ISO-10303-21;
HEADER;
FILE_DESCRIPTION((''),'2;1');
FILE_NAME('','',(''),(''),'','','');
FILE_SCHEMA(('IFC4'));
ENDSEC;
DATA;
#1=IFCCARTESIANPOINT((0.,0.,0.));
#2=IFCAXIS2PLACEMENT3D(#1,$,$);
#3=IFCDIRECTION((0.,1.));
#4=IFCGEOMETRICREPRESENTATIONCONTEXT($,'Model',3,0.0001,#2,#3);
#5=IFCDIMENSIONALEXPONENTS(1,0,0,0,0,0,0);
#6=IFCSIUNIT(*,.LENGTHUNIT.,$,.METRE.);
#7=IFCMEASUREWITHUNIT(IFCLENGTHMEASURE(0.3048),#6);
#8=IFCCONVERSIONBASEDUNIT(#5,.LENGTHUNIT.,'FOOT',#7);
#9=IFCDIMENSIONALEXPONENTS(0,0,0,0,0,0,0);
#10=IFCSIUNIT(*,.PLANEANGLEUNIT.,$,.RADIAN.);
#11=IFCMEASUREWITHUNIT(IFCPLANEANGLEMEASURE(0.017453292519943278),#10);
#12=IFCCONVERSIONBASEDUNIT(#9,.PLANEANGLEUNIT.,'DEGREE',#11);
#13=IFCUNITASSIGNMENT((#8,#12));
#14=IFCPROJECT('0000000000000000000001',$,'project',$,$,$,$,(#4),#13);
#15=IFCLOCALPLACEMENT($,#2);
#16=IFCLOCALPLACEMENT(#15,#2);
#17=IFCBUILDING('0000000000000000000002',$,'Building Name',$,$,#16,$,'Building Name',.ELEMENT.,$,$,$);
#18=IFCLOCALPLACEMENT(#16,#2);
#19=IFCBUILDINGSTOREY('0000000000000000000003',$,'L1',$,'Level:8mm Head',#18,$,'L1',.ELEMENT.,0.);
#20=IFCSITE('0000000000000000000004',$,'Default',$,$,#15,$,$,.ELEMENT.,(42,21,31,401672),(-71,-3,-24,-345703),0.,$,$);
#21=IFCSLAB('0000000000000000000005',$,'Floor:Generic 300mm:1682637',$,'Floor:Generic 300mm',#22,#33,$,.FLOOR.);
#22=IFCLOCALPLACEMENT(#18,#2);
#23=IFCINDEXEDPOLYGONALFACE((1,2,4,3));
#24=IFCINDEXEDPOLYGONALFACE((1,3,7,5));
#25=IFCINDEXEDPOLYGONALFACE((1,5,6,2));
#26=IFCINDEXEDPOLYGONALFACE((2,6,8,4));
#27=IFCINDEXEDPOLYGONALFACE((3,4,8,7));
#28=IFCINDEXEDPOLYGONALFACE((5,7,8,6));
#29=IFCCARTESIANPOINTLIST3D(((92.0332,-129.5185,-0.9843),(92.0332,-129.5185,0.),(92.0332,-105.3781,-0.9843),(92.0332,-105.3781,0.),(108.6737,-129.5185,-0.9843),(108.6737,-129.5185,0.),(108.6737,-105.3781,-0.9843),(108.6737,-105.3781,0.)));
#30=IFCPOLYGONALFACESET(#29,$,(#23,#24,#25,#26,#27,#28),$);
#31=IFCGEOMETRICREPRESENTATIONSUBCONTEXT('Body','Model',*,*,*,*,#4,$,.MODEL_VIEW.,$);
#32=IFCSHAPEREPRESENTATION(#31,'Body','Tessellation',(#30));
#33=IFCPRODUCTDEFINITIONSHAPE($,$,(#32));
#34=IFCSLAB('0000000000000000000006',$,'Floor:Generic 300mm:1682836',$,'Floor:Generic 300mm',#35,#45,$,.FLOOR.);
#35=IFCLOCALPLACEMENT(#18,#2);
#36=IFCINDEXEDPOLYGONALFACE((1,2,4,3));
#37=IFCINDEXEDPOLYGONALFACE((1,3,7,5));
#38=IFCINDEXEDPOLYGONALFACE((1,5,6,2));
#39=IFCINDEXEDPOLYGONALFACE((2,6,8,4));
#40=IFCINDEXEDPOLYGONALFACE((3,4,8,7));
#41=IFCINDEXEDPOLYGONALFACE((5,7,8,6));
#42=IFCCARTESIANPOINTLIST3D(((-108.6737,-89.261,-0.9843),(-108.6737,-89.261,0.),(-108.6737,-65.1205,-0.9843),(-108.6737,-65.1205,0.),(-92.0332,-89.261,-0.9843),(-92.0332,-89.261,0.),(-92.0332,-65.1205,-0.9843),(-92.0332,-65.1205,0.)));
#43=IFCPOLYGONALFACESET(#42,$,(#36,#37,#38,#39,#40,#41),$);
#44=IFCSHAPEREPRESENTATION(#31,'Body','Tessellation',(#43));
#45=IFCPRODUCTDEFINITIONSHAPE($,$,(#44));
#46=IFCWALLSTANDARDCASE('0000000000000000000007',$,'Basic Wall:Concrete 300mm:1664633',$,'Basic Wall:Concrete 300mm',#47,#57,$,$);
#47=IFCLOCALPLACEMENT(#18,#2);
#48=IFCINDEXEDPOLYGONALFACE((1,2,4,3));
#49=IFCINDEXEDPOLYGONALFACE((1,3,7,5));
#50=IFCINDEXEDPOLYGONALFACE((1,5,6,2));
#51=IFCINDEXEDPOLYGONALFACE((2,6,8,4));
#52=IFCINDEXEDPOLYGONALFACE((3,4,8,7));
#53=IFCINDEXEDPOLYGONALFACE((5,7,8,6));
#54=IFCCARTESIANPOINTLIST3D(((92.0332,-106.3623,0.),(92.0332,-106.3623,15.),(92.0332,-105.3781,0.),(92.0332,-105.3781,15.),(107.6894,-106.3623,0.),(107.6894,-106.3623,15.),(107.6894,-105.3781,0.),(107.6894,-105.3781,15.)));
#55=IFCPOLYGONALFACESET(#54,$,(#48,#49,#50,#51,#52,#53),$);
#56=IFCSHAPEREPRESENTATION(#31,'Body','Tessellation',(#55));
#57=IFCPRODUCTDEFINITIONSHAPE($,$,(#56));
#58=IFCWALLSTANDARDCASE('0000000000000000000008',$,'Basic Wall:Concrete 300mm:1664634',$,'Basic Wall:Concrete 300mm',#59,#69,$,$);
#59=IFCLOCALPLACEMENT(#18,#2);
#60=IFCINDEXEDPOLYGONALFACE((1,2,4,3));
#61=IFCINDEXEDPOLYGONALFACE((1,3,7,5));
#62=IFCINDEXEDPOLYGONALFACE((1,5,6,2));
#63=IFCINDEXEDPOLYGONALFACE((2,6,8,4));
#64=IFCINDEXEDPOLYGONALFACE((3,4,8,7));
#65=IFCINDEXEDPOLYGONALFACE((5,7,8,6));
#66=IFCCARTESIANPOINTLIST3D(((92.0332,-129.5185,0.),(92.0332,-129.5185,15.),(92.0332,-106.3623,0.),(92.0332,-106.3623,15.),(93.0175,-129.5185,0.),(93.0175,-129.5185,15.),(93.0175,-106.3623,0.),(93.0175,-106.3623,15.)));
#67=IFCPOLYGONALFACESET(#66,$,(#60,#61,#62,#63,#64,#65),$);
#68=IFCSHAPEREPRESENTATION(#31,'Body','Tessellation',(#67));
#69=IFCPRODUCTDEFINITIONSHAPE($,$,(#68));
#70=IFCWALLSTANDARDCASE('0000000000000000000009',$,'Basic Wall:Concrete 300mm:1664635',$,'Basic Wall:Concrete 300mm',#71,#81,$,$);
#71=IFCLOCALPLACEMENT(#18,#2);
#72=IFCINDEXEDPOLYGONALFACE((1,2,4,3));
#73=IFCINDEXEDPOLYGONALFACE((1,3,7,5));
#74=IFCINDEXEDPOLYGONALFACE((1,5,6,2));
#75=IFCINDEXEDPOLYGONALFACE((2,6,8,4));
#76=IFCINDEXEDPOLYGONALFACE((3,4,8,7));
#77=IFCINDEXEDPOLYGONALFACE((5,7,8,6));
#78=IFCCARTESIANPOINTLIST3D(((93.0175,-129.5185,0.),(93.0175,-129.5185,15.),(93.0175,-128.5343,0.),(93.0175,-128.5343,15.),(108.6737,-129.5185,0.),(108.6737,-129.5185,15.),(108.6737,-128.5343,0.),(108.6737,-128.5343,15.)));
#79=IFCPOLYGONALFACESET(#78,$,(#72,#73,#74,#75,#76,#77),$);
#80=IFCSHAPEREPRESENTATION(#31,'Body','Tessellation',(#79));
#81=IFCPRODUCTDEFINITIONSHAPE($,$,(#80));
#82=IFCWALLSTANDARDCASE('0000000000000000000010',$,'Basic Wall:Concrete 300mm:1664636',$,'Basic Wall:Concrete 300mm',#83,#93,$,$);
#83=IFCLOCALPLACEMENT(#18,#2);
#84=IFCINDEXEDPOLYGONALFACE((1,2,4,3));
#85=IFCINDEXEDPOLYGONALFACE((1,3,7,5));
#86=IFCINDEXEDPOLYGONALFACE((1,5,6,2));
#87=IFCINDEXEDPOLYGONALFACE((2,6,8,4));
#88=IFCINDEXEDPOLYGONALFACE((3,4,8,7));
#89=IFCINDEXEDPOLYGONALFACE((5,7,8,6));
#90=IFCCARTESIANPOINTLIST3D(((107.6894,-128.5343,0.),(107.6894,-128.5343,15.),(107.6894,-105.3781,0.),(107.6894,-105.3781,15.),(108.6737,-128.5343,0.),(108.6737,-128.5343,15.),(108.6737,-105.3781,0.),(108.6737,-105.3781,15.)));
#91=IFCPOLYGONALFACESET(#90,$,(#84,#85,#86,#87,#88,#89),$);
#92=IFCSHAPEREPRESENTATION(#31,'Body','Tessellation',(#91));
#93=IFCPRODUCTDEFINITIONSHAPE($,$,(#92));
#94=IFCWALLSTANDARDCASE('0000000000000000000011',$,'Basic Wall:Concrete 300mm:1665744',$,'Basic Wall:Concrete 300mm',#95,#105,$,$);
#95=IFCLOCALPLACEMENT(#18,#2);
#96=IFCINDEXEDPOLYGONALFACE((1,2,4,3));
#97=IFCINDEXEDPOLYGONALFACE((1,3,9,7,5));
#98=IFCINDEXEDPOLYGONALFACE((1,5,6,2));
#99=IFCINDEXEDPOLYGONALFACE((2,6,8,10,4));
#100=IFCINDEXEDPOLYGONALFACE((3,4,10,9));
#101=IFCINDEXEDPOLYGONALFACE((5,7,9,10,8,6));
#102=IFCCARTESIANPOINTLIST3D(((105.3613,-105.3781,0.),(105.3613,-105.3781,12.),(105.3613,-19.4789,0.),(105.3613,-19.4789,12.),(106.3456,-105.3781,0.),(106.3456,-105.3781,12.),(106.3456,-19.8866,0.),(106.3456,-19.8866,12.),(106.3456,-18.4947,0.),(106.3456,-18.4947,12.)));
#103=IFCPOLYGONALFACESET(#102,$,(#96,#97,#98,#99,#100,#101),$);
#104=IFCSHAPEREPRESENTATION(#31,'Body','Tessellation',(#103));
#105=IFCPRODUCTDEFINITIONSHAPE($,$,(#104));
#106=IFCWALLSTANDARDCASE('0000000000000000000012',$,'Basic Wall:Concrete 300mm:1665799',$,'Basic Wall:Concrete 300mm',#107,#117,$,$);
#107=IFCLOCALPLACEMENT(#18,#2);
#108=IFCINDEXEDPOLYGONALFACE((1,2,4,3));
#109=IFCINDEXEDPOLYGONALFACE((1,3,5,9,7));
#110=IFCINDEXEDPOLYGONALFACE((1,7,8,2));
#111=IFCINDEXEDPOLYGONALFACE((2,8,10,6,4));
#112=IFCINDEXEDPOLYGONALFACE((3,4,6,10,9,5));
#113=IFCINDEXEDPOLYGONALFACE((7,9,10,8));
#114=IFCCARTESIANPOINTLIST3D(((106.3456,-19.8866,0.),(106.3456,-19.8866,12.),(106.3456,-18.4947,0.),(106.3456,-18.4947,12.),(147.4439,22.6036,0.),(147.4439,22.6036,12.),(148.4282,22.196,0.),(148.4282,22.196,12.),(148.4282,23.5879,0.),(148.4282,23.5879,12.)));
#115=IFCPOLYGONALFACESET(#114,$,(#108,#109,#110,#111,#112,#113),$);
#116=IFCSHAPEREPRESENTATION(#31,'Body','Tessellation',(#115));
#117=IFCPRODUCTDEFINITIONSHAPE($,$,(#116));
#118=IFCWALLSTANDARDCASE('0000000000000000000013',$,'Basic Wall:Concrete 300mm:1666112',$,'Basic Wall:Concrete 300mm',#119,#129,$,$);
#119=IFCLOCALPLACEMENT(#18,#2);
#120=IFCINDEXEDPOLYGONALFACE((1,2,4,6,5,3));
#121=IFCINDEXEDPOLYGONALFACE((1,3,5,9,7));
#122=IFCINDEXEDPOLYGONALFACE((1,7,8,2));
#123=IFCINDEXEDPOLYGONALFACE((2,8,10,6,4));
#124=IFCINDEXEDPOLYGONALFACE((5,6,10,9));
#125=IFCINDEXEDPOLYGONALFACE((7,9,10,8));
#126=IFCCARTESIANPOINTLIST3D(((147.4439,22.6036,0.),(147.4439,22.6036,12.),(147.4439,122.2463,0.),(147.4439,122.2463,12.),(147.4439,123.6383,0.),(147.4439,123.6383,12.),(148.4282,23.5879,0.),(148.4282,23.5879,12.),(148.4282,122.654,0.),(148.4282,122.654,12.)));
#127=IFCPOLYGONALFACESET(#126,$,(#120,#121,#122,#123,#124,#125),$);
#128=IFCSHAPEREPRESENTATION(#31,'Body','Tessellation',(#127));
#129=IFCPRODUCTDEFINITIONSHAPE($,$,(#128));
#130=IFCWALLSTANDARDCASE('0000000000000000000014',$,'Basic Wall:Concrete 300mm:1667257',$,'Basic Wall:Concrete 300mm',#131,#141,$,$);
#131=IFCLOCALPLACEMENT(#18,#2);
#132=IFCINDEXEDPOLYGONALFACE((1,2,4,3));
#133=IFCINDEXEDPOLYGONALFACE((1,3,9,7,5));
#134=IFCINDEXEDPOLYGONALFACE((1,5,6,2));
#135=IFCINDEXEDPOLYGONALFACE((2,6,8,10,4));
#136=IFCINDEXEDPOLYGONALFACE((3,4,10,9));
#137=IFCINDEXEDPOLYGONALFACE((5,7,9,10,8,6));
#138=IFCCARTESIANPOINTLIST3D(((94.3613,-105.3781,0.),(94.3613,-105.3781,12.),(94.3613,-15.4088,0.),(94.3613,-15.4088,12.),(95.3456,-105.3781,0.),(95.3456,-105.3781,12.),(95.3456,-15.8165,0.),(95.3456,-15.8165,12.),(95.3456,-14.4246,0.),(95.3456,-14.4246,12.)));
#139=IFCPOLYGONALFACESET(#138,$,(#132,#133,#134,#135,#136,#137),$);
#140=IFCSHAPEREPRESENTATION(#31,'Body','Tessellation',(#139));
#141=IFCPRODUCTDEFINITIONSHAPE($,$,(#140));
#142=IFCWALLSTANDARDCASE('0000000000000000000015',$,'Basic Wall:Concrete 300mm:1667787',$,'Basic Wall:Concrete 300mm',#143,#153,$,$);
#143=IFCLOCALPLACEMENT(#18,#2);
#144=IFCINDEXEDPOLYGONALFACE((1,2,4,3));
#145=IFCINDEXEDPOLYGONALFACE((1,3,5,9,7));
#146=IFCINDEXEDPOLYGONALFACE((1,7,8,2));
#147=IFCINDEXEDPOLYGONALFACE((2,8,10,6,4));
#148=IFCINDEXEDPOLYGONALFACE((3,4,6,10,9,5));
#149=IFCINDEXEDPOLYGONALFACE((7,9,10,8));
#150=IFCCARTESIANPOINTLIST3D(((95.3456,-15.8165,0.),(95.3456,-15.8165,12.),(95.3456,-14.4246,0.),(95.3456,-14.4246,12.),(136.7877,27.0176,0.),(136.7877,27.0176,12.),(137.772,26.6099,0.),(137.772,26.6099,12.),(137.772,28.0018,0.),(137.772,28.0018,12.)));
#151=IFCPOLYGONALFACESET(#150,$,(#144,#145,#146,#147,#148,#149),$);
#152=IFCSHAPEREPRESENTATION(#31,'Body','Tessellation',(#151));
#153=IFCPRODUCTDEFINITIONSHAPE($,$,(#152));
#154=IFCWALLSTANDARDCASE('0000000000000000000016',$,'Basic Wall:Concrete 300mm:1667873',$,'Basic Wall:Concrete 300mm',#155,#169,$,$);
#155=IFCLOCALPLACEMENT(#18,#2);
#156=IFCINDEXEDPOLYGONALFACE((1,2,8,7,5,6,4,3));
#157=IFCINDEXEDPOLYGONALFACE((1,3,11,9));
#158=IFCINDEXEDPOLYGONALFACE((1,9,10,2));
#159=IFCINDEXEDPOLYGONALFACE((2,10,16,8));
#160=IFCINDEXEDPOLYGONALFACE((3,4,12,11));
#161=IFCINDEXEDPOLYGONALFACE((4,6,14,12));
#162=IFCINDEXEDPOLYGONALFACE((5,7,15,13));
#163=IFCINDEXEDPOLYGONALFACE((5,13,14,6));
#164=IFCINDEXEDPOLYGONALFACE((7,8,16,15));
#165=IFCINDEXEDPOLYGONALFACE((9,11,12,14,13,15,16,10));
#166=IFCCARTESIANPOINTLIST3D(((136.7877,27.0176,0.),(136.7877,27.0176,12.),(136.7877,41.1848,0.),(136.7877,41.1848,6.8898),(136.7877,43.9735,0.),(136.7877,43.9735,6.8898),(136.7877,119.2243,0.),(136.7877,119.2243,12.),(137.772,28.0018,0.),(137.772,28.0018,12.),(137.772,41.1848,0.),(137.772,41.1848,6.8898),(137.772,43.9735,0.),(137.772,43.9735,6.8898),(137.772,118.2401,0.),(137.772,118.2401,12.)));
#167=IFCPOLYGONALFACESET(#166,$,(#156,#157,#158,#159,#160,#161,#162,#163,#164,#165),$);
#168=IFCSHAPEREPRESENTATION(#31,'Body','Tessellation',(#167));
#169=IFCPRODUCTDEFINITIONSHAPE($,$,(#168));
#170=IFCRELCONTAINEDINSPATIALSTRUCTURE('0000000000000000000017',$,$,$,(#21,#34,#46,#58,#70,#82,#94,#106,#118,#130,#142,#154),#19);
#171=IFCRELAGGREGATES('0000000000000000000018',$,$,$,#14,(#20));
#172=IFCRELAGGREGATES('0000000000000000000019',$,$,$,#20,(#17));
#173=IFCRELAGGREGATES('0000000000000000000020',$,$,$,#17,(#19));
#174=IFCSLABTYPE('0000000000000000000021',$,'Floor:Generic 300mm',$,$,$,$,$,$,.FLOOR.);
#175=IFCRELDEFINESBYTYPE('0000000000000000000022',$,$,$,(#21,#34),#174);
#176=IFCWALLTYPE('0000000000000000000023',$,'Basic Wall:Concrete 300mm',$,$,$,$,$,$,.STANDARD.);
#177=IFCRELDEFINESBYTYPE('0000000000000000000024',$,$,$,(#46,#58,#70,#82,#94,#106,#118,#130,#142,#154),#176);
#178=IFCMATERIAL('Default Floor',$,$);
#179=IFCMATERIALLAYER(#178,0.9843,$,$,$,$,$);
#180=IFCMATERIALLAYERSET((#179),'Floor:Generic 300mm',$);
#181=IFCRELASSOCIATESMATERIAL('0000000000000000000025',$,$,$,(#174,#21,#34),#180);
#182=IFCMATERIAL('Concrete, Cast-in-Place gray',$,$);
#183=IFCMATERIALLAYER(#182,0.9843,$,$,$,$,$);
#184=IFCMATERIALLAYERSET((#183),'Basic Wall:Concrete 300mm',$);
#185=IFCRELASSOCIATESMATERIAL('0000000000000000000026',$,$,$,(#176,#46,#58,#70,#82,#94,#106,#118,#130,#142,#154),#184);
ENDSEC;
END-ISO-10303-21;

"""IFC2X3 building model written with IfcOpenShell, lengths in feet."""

from ifc_helpers import new_model, entity, si_unit, converted_unit, direction, frame, frame_2d, origin, place, context, subcontext, project, spatial, polyline, rectangle, outline, extrude, material, layer, layer_set, layer_usage, type_object, element, save


model = new_model("IFC2X3")

# Units and contexts
model_context = context("Model", 3, precision=0.0001, world=origin(), true_north=direction((0.0, 1.0)))
body_context = subcontext(model_context, "Body", "Model", "MODEL_VIEW")
ifc_project = project(units=[converted_unit("LENGTHUNIT", "FOOT", entity("IfcLengthMeasure", 0.3048), si_unit("LENGTHUNIT", "METRE"), dimensions=[1, 0, 0, 0, 0, 0, 0]), converted_unit("PLANEANGLEUNIT", "DEGREE", entity("IfcPlaneAngleMeasure", 0.017453292519943278), si_unit("PLANEANGLEUNIT", "RADIAN"), dimensions=[0, 0, 0, 0, 0, 0, 0])], contexts=[model_context])

# Site, building, storey
site_placement = place(None, origin())
site = spatial("IfcSite", under=ifc_project, at=site_placement, Name="Default", CompositionType="ELEMENT", RefLatitude=(42, 21, 31, 401672), RefLongitude=(-71, -3, -24, -345703), RefElevation=0.0)
building_placement = place(site_placement, origin())
building = spatial("IfcBuilding", under=site, at=building_placement, Name="Building Name", LongName="Building Name", CompositionType="ELEMENT")
storey_placement = place(building_placement, origin())
storey = spatial("IfcBuildingStorey", under=building, at=storey_placement, Name="L1", ObjectType="Level:8mm Head", LongName="L1", CompositionType="ELEMENT", Elevation=0.0)

# Slabs
ifc_material_1 = material(Name="Default Floor")
ifc_layer_1 = layer(ifc_material_1, 0.9843)
ifc_layer_set_1 = layer_set([ifc_layer_1], Name="Floor:Generic 300mm")
slab_type = type_object("IfcSlabType", Name="Floor:Generic 300mm", PredefinedType="FLOOR", material=ifc_layer_set_1)
ifc_layer_usage_1 = layer_usage(ifc_layer_set_1, "AXIS3", "POSITIVE", 0.0)
slab_1_placement = place(storey_placement, origin())
element("IfcSlab", 1, at=slab_1_placement, inside=storey, type_object=slab_type, material=ifc_layer_usage_1, Name="Floor:Generic 300mm:1682637", ObjectType="Floor:Generic 300mm", PredefinedType="FLOOR", context=body_context, shape_type="SweptSolid", body=[
    extrude(rectangle(XDim=24.1404, YDim=16.6404, at=frame_2d((0.0, 0.0), x_axis=(1.0, 0.0))), frame((100.3535, -117.4483, 0.0), z_axis=(0.0, 0.0, -1.0), x_axis=(0.0, 1.0, 0.0)), (0.0, 0.0, 1.0), 0.9843),
])
ifc_layer_usage_2 = layer_usage(ifc_layer_set_1, "AXIS3", "POSITIVE", 0.0)
slab_2_placement = place(storey_placement, origin())
element("IfcSlab", 2, at=slab_2_placement, inside=storey, type_object=slab_type, material=ifc_layer_usage_2, Name="Floor:Generic 300mm:1682836", ObjectType="Floor:Generic 300mm", PredefinedType="FLOOR", context=body_context, shape_type="SweptSolid", body=[
    extrude(rectangle(XDim=24.1404, YDim=16.6404, at=frame_2d((0.0, 0.0), x_axis=(1.0, 0.0))), frame((-100.3535, -77.1908, 0.0), z_axis=(0.0, 0.0, -1.0), x_axis=(0.0, 1.0, 0.0)), (0.0, 0.0, 1.0), 0.9843),
])

# Walls
ifc_material_2 = material(Name="Concrete, Cast-in-Place gray")
ifc_layer_2 = layer(ifc_material_2, 0.9843)
ifc_layer_set_2 = layer_set([ifc_layer_2], Name="Basic Wall:Concrete 300mm")
ifc_layer_usage_3 = layer_usage(ifc_layer_set_2, "AXIS2", "NEGATIVE", 0.4921)
wall_type = type_object("IfcWallType", Name="Basic Wall:Concrete 300mm", PredefinedType="STANDARD", material=ifc_layer_set_2)
wall_1_placement = place(storey_placement, frame((92.0332, -105.8702, 0.0)))
element("IfcWallStandardCase", 3, at=wall_1_placement, inside=storey, type_object=wall_type, material=ifc_layer_usage_3, Name="Basic Wall:Concrete 300mm:1664633", ObjectType="Basic Wall:Concrete 300mm", context=body_context, shape_type="SweptSolid", body=[
    extrude(rectangle(XDim=15.6562, YDim=0.9843, at=frame_2d((7.8281, 0.0), x_axis=(-1.0, 0.0))), origin(), (0.0, 0.0, 1.0), 15.0),
])
ifc_layer_usage_4 = layer_usage(ifc_layer_set_2, "AXIS2", "NEGATIVE", 0.4921)
wall_2_placement = place(storey_placement, frame((92.5254, -129.5185, 0.0), z_axis=(0.0, 0.0, 1.0), x_axis=(0.0, 1.0, 0.0)))
element("IfcWallStandardCase", 4, at=wall_2_placement, inside=storey, type_object=wall_type, material=ifc_layer_usage_4, Name="Basic Wall:Concrete 300mm:1664634", ObjectType="Basic Wall:Concrete 300mm", context=body_context, shape_type="SweptSolid", body=[
    extrude(rectangle(XDim=23.1562, YDim=0.9843, at=frame_2d((11.5781, 0.0), x_axis=(-1.0, 0.0))), origin(), (0.0, 0.0, 1.0), 15.0),
])
ifc_layer_usage_5 = layer_usage(ifc_layer_set_2, "AXIS2", "NEGATIVE", 0.4921)
wall_3_placement = place(storey_placement, frame((108.6737, -129.0264, 0.0), z_axis=(0.0, 0.0, 1.0), x_axis=(-1.0, 0.0, 0.0)))
element("IfcWallStandardCase", 5, at=wall_3_placement, inside=storey, type_object=wall_type, material=ifc_layer_usage_5, Name="Basic Wall:Concrete 300mm:1664635", ObjectType="Basic Wall:Concrete 300mm", context=body_context, shape_type="SweptSolid", body=[
    extrude(rectangle(XDim=15.6562, YDim=0.9843, at=frame_2d((7.8281, 0.0), x_axis=(-1.0, 0.0))), origin(), (0.0, 0.0, 1.0), 15.0),
])
ifc_layer_usage_6 = layer_usage(ifc_layer_set_2, "AXIS2", "NEGATIVE", 0.4921)
wall_4_placement = place(storey_placement, frame((108.1815, -105.3781, 0.0), z_axis=(0.0, 0.0, 1.0), x_axis=(0.0, -1.0, 0.0)))
element("IfcWallStandardCase", 6, at=wall_4_placement, inside=storey, type_object=wall_type, material=ifc_layer_usage_6, Name="Basic Wall:Concrete 300mm:1664636", ObjectType="Basic Wall:Concrete 300mm", context=body_context, shape_type="SweptSolid", body=[
    extrude(rectangle(XDim=23.1562, YDim=0.9843, at=frame_2d((11.5781, 0.0), x_axis=(-1.0, 0.0))), origin(), (0.0, 0.0, 1.0), 15.0),
])
ifc_layer_usage_7 = layer_usage(ifc_layer_set_2, "AXIS2", "NEGATIVE", 0.4921)
wall_5_placement = place(storey_placement, frame((105.8535, -105.3781, 0.0), z_axis=(0.0, 0.0, 1.0), x_axis=(0.0, 1.0, 0.0)))
element("IfcWallStandardCase", 7, at=wall_5_placement, inside=storey, type_object=wall_type, material=ifc_layer_usage_7, Name="Basic Wall:Concrete 300mm:1665744", ObjectType="Basic Wall:Concrete 300mm", context=body_context, shape_type="SweptSolid", body=[
    extrude(outline(polyline([(86.8834, -0.4921), (85.8992, 0.4921), (0.0, 0.4921), (0.0, -0.4921), (85.4915, -0.4921), (86.8834, -0.4921)])), origin(), (0.0, 0.0, 1.0), 12.0),
])
ifc_layer_usage_8 = layer_usage(ifc_layer_set_2, "AXIS2", "NEGATIVE", 0.4921)
wall_6_placement = place(storey_placement, frame((105.9976, -19.5386, 0.0), z_axis=(0.0, 0.0, 1.0), x_axis=(0.707107, 0.707107, 0.0)))
element("IfcWallStandardCase", 8, at=wall_6_placement, inside=storey, type_object=wall_type, material=ifc_layer_usage_8, Name="Basic Wall:Concrete 300mm:1665799", ObjectType="Basic Wall:Concrete 300mm", context=body_context, shape_type="SweptSolid", body=[
    extrude(outline(polyline([(59.5137, -0.4921), (60.498, 0.4921), (59.1061, 0.4921), (0.9843, 0.4921), (0.0, -0.4921), (59.5137, -0.4921)])), origin(), (0.0, 0.0, 1.0), 12.0),
])
ifc_layer_usage_9 = layer_usage(ifc_layer_set_2, "AXIS2", "NEGATIVE", 0.4921)
wall_7_placement = place(storey_placement, frame((147.936, 22.6036, 0.0), z_axis=(0.0, 0.0, 1.0), x_axis=(0.0, 1.0, 0.0)))
element("IfcWallStandardCase", 9, at=wall_7_placement, inside=storey, type_object=wall_type, material=ifc_layer_usage_9, Name="Basic Wall:Concrete 300mm:1666112", ObjectType="Basic Wall:Concrete 300mm", context=body_context, shape_type="SweptSolid", body=[
    extrude(outline(polyline([(100.0504, -0.4921), (101.0346, 0.4921), (99.6427, 0.4921), (0.0, 0.4921), (0.9843, -0.4921), (100.0504, -0.4921)])), origin(), (0.0, 0.0, 1.0), 12.0),
])
ifc_layer_usage_10 = layer_usage(ifc_layer_set_2, "AXIS2", "NEGATIVE", 0.4921)
wall_8_placement = place(storey_placement, frame((94.8535, -105.3781, 0.0), z_axis=(0.0, 0.0, 1.0), x_axis=(0.0, 1.0, 0.0)))
element("IfcWallStandardCase", 10, at=wall_8_placement, inside=storey, type_object=wall_type, material=ifc_layer_usage_10, Name="Basic Wall:Concrete 300mm:1667257", ObjectType="Basic Wall:Concrete 300mm", context=body_context, shape_type="SweptSolid", body=[
    extrude(outline(polyline([(90.9535, -0.4921), (89.9693, 0.4921), (0.0, 0.4921), (0.0, -0.4921), (89.5616, -0.4921), (90.9535, -0.4921)])), origin(), (0.0, 0.0, 1.0), 12.0),
])
ifc_layer_usage_11 = layer_usage(ifc_layer_set_2, "AXIS2", "NEGATIVE", 0.4921)
wall_9_placement = place(storey_placement, frame((94.9976, -15.4685, 0.0), z_axis=(0.0, 0.0, 1.0), x_axis=(0.707107, 0.707107, 0.0)))
element("IfcWallStandardCase", 11, at=wall_9_placement, inside=storey, type_object=wall_type, material=ifc_layer_usage_11, Name="Basic Wall:Concrete 300mm:1667787", ObjectType="Basic Wall:Concrete 300mm", context=body_context, shape_type="SweptSolid", body=[
    extrude(outline(polyline([(60.0, -0.4921), (60.9843, 0.4921), (59.5923, 0.4921), (0.9843, 0.4921), (0.0, -0.4921), (60.0, -0.4921)])), origin(), (0.0, 0.0, 1.0), 12.0),
])

# Wall, opening
ifc_layer_usage_12 = layer_usage(ifc_layer_set_2, "AXIS2", "NEGATIVE", 0.4921)
wall_10_placement = place(storey_placement, frame((137.2799, 27.0176, 0.0), z_axis=(0.0, 0.0, 1.0), x_axis=(0.0, 1.0, 0.0)))
wall_10 = element("IfcWallStandardCase", 12, at=wall_10_placement, inside=storey, type_object=wall_type, material=ifc_layer_usage_12, Name="Basic Wall:Concrete 300mm:1667873", ObjectType="Basic Wall:Concrete 300mm", context=body_context, shape_type="SweptSolid", body=[
    extrude(outline(polyline([(0.9843, -0.4921), (91.2225, -0.4921), (92.2068, 0.4921), (90.8148, 0.4921), (19.3818, 0.4921), (18.3975, 0.4921), (12.7256, 0.4921), (11.7414, 0.4921), (0.0, 0.4921), (0.9843, -0.4921)])), origin(), (0.0, 0.0, 1.0), 12.0),
])
opening_1_placement = place(wall_10_placement, frame((14.1672, -0.4921, 0.0)))
element("IfcOpeningElement", 13, at=opening_1_placement, cuts=wall_10, ObjectType="Opening", context=body_context, shape_type="SweptSolid", body=[
    extrude(rectangle(XDim=6.8898, YDim=2.7887, at=frame_2d((3.4449, 1.3944), x_axis=(1.0, 0.0))), frame((0.0, 0.0, 0.0), z_axis=(0.0, 1.0, 0.0), x_axis=(0.0, 0.0, 1.0)), (0.0, 0.0, 1.0), 0.9843),
])

save(model, "model.ifc")
